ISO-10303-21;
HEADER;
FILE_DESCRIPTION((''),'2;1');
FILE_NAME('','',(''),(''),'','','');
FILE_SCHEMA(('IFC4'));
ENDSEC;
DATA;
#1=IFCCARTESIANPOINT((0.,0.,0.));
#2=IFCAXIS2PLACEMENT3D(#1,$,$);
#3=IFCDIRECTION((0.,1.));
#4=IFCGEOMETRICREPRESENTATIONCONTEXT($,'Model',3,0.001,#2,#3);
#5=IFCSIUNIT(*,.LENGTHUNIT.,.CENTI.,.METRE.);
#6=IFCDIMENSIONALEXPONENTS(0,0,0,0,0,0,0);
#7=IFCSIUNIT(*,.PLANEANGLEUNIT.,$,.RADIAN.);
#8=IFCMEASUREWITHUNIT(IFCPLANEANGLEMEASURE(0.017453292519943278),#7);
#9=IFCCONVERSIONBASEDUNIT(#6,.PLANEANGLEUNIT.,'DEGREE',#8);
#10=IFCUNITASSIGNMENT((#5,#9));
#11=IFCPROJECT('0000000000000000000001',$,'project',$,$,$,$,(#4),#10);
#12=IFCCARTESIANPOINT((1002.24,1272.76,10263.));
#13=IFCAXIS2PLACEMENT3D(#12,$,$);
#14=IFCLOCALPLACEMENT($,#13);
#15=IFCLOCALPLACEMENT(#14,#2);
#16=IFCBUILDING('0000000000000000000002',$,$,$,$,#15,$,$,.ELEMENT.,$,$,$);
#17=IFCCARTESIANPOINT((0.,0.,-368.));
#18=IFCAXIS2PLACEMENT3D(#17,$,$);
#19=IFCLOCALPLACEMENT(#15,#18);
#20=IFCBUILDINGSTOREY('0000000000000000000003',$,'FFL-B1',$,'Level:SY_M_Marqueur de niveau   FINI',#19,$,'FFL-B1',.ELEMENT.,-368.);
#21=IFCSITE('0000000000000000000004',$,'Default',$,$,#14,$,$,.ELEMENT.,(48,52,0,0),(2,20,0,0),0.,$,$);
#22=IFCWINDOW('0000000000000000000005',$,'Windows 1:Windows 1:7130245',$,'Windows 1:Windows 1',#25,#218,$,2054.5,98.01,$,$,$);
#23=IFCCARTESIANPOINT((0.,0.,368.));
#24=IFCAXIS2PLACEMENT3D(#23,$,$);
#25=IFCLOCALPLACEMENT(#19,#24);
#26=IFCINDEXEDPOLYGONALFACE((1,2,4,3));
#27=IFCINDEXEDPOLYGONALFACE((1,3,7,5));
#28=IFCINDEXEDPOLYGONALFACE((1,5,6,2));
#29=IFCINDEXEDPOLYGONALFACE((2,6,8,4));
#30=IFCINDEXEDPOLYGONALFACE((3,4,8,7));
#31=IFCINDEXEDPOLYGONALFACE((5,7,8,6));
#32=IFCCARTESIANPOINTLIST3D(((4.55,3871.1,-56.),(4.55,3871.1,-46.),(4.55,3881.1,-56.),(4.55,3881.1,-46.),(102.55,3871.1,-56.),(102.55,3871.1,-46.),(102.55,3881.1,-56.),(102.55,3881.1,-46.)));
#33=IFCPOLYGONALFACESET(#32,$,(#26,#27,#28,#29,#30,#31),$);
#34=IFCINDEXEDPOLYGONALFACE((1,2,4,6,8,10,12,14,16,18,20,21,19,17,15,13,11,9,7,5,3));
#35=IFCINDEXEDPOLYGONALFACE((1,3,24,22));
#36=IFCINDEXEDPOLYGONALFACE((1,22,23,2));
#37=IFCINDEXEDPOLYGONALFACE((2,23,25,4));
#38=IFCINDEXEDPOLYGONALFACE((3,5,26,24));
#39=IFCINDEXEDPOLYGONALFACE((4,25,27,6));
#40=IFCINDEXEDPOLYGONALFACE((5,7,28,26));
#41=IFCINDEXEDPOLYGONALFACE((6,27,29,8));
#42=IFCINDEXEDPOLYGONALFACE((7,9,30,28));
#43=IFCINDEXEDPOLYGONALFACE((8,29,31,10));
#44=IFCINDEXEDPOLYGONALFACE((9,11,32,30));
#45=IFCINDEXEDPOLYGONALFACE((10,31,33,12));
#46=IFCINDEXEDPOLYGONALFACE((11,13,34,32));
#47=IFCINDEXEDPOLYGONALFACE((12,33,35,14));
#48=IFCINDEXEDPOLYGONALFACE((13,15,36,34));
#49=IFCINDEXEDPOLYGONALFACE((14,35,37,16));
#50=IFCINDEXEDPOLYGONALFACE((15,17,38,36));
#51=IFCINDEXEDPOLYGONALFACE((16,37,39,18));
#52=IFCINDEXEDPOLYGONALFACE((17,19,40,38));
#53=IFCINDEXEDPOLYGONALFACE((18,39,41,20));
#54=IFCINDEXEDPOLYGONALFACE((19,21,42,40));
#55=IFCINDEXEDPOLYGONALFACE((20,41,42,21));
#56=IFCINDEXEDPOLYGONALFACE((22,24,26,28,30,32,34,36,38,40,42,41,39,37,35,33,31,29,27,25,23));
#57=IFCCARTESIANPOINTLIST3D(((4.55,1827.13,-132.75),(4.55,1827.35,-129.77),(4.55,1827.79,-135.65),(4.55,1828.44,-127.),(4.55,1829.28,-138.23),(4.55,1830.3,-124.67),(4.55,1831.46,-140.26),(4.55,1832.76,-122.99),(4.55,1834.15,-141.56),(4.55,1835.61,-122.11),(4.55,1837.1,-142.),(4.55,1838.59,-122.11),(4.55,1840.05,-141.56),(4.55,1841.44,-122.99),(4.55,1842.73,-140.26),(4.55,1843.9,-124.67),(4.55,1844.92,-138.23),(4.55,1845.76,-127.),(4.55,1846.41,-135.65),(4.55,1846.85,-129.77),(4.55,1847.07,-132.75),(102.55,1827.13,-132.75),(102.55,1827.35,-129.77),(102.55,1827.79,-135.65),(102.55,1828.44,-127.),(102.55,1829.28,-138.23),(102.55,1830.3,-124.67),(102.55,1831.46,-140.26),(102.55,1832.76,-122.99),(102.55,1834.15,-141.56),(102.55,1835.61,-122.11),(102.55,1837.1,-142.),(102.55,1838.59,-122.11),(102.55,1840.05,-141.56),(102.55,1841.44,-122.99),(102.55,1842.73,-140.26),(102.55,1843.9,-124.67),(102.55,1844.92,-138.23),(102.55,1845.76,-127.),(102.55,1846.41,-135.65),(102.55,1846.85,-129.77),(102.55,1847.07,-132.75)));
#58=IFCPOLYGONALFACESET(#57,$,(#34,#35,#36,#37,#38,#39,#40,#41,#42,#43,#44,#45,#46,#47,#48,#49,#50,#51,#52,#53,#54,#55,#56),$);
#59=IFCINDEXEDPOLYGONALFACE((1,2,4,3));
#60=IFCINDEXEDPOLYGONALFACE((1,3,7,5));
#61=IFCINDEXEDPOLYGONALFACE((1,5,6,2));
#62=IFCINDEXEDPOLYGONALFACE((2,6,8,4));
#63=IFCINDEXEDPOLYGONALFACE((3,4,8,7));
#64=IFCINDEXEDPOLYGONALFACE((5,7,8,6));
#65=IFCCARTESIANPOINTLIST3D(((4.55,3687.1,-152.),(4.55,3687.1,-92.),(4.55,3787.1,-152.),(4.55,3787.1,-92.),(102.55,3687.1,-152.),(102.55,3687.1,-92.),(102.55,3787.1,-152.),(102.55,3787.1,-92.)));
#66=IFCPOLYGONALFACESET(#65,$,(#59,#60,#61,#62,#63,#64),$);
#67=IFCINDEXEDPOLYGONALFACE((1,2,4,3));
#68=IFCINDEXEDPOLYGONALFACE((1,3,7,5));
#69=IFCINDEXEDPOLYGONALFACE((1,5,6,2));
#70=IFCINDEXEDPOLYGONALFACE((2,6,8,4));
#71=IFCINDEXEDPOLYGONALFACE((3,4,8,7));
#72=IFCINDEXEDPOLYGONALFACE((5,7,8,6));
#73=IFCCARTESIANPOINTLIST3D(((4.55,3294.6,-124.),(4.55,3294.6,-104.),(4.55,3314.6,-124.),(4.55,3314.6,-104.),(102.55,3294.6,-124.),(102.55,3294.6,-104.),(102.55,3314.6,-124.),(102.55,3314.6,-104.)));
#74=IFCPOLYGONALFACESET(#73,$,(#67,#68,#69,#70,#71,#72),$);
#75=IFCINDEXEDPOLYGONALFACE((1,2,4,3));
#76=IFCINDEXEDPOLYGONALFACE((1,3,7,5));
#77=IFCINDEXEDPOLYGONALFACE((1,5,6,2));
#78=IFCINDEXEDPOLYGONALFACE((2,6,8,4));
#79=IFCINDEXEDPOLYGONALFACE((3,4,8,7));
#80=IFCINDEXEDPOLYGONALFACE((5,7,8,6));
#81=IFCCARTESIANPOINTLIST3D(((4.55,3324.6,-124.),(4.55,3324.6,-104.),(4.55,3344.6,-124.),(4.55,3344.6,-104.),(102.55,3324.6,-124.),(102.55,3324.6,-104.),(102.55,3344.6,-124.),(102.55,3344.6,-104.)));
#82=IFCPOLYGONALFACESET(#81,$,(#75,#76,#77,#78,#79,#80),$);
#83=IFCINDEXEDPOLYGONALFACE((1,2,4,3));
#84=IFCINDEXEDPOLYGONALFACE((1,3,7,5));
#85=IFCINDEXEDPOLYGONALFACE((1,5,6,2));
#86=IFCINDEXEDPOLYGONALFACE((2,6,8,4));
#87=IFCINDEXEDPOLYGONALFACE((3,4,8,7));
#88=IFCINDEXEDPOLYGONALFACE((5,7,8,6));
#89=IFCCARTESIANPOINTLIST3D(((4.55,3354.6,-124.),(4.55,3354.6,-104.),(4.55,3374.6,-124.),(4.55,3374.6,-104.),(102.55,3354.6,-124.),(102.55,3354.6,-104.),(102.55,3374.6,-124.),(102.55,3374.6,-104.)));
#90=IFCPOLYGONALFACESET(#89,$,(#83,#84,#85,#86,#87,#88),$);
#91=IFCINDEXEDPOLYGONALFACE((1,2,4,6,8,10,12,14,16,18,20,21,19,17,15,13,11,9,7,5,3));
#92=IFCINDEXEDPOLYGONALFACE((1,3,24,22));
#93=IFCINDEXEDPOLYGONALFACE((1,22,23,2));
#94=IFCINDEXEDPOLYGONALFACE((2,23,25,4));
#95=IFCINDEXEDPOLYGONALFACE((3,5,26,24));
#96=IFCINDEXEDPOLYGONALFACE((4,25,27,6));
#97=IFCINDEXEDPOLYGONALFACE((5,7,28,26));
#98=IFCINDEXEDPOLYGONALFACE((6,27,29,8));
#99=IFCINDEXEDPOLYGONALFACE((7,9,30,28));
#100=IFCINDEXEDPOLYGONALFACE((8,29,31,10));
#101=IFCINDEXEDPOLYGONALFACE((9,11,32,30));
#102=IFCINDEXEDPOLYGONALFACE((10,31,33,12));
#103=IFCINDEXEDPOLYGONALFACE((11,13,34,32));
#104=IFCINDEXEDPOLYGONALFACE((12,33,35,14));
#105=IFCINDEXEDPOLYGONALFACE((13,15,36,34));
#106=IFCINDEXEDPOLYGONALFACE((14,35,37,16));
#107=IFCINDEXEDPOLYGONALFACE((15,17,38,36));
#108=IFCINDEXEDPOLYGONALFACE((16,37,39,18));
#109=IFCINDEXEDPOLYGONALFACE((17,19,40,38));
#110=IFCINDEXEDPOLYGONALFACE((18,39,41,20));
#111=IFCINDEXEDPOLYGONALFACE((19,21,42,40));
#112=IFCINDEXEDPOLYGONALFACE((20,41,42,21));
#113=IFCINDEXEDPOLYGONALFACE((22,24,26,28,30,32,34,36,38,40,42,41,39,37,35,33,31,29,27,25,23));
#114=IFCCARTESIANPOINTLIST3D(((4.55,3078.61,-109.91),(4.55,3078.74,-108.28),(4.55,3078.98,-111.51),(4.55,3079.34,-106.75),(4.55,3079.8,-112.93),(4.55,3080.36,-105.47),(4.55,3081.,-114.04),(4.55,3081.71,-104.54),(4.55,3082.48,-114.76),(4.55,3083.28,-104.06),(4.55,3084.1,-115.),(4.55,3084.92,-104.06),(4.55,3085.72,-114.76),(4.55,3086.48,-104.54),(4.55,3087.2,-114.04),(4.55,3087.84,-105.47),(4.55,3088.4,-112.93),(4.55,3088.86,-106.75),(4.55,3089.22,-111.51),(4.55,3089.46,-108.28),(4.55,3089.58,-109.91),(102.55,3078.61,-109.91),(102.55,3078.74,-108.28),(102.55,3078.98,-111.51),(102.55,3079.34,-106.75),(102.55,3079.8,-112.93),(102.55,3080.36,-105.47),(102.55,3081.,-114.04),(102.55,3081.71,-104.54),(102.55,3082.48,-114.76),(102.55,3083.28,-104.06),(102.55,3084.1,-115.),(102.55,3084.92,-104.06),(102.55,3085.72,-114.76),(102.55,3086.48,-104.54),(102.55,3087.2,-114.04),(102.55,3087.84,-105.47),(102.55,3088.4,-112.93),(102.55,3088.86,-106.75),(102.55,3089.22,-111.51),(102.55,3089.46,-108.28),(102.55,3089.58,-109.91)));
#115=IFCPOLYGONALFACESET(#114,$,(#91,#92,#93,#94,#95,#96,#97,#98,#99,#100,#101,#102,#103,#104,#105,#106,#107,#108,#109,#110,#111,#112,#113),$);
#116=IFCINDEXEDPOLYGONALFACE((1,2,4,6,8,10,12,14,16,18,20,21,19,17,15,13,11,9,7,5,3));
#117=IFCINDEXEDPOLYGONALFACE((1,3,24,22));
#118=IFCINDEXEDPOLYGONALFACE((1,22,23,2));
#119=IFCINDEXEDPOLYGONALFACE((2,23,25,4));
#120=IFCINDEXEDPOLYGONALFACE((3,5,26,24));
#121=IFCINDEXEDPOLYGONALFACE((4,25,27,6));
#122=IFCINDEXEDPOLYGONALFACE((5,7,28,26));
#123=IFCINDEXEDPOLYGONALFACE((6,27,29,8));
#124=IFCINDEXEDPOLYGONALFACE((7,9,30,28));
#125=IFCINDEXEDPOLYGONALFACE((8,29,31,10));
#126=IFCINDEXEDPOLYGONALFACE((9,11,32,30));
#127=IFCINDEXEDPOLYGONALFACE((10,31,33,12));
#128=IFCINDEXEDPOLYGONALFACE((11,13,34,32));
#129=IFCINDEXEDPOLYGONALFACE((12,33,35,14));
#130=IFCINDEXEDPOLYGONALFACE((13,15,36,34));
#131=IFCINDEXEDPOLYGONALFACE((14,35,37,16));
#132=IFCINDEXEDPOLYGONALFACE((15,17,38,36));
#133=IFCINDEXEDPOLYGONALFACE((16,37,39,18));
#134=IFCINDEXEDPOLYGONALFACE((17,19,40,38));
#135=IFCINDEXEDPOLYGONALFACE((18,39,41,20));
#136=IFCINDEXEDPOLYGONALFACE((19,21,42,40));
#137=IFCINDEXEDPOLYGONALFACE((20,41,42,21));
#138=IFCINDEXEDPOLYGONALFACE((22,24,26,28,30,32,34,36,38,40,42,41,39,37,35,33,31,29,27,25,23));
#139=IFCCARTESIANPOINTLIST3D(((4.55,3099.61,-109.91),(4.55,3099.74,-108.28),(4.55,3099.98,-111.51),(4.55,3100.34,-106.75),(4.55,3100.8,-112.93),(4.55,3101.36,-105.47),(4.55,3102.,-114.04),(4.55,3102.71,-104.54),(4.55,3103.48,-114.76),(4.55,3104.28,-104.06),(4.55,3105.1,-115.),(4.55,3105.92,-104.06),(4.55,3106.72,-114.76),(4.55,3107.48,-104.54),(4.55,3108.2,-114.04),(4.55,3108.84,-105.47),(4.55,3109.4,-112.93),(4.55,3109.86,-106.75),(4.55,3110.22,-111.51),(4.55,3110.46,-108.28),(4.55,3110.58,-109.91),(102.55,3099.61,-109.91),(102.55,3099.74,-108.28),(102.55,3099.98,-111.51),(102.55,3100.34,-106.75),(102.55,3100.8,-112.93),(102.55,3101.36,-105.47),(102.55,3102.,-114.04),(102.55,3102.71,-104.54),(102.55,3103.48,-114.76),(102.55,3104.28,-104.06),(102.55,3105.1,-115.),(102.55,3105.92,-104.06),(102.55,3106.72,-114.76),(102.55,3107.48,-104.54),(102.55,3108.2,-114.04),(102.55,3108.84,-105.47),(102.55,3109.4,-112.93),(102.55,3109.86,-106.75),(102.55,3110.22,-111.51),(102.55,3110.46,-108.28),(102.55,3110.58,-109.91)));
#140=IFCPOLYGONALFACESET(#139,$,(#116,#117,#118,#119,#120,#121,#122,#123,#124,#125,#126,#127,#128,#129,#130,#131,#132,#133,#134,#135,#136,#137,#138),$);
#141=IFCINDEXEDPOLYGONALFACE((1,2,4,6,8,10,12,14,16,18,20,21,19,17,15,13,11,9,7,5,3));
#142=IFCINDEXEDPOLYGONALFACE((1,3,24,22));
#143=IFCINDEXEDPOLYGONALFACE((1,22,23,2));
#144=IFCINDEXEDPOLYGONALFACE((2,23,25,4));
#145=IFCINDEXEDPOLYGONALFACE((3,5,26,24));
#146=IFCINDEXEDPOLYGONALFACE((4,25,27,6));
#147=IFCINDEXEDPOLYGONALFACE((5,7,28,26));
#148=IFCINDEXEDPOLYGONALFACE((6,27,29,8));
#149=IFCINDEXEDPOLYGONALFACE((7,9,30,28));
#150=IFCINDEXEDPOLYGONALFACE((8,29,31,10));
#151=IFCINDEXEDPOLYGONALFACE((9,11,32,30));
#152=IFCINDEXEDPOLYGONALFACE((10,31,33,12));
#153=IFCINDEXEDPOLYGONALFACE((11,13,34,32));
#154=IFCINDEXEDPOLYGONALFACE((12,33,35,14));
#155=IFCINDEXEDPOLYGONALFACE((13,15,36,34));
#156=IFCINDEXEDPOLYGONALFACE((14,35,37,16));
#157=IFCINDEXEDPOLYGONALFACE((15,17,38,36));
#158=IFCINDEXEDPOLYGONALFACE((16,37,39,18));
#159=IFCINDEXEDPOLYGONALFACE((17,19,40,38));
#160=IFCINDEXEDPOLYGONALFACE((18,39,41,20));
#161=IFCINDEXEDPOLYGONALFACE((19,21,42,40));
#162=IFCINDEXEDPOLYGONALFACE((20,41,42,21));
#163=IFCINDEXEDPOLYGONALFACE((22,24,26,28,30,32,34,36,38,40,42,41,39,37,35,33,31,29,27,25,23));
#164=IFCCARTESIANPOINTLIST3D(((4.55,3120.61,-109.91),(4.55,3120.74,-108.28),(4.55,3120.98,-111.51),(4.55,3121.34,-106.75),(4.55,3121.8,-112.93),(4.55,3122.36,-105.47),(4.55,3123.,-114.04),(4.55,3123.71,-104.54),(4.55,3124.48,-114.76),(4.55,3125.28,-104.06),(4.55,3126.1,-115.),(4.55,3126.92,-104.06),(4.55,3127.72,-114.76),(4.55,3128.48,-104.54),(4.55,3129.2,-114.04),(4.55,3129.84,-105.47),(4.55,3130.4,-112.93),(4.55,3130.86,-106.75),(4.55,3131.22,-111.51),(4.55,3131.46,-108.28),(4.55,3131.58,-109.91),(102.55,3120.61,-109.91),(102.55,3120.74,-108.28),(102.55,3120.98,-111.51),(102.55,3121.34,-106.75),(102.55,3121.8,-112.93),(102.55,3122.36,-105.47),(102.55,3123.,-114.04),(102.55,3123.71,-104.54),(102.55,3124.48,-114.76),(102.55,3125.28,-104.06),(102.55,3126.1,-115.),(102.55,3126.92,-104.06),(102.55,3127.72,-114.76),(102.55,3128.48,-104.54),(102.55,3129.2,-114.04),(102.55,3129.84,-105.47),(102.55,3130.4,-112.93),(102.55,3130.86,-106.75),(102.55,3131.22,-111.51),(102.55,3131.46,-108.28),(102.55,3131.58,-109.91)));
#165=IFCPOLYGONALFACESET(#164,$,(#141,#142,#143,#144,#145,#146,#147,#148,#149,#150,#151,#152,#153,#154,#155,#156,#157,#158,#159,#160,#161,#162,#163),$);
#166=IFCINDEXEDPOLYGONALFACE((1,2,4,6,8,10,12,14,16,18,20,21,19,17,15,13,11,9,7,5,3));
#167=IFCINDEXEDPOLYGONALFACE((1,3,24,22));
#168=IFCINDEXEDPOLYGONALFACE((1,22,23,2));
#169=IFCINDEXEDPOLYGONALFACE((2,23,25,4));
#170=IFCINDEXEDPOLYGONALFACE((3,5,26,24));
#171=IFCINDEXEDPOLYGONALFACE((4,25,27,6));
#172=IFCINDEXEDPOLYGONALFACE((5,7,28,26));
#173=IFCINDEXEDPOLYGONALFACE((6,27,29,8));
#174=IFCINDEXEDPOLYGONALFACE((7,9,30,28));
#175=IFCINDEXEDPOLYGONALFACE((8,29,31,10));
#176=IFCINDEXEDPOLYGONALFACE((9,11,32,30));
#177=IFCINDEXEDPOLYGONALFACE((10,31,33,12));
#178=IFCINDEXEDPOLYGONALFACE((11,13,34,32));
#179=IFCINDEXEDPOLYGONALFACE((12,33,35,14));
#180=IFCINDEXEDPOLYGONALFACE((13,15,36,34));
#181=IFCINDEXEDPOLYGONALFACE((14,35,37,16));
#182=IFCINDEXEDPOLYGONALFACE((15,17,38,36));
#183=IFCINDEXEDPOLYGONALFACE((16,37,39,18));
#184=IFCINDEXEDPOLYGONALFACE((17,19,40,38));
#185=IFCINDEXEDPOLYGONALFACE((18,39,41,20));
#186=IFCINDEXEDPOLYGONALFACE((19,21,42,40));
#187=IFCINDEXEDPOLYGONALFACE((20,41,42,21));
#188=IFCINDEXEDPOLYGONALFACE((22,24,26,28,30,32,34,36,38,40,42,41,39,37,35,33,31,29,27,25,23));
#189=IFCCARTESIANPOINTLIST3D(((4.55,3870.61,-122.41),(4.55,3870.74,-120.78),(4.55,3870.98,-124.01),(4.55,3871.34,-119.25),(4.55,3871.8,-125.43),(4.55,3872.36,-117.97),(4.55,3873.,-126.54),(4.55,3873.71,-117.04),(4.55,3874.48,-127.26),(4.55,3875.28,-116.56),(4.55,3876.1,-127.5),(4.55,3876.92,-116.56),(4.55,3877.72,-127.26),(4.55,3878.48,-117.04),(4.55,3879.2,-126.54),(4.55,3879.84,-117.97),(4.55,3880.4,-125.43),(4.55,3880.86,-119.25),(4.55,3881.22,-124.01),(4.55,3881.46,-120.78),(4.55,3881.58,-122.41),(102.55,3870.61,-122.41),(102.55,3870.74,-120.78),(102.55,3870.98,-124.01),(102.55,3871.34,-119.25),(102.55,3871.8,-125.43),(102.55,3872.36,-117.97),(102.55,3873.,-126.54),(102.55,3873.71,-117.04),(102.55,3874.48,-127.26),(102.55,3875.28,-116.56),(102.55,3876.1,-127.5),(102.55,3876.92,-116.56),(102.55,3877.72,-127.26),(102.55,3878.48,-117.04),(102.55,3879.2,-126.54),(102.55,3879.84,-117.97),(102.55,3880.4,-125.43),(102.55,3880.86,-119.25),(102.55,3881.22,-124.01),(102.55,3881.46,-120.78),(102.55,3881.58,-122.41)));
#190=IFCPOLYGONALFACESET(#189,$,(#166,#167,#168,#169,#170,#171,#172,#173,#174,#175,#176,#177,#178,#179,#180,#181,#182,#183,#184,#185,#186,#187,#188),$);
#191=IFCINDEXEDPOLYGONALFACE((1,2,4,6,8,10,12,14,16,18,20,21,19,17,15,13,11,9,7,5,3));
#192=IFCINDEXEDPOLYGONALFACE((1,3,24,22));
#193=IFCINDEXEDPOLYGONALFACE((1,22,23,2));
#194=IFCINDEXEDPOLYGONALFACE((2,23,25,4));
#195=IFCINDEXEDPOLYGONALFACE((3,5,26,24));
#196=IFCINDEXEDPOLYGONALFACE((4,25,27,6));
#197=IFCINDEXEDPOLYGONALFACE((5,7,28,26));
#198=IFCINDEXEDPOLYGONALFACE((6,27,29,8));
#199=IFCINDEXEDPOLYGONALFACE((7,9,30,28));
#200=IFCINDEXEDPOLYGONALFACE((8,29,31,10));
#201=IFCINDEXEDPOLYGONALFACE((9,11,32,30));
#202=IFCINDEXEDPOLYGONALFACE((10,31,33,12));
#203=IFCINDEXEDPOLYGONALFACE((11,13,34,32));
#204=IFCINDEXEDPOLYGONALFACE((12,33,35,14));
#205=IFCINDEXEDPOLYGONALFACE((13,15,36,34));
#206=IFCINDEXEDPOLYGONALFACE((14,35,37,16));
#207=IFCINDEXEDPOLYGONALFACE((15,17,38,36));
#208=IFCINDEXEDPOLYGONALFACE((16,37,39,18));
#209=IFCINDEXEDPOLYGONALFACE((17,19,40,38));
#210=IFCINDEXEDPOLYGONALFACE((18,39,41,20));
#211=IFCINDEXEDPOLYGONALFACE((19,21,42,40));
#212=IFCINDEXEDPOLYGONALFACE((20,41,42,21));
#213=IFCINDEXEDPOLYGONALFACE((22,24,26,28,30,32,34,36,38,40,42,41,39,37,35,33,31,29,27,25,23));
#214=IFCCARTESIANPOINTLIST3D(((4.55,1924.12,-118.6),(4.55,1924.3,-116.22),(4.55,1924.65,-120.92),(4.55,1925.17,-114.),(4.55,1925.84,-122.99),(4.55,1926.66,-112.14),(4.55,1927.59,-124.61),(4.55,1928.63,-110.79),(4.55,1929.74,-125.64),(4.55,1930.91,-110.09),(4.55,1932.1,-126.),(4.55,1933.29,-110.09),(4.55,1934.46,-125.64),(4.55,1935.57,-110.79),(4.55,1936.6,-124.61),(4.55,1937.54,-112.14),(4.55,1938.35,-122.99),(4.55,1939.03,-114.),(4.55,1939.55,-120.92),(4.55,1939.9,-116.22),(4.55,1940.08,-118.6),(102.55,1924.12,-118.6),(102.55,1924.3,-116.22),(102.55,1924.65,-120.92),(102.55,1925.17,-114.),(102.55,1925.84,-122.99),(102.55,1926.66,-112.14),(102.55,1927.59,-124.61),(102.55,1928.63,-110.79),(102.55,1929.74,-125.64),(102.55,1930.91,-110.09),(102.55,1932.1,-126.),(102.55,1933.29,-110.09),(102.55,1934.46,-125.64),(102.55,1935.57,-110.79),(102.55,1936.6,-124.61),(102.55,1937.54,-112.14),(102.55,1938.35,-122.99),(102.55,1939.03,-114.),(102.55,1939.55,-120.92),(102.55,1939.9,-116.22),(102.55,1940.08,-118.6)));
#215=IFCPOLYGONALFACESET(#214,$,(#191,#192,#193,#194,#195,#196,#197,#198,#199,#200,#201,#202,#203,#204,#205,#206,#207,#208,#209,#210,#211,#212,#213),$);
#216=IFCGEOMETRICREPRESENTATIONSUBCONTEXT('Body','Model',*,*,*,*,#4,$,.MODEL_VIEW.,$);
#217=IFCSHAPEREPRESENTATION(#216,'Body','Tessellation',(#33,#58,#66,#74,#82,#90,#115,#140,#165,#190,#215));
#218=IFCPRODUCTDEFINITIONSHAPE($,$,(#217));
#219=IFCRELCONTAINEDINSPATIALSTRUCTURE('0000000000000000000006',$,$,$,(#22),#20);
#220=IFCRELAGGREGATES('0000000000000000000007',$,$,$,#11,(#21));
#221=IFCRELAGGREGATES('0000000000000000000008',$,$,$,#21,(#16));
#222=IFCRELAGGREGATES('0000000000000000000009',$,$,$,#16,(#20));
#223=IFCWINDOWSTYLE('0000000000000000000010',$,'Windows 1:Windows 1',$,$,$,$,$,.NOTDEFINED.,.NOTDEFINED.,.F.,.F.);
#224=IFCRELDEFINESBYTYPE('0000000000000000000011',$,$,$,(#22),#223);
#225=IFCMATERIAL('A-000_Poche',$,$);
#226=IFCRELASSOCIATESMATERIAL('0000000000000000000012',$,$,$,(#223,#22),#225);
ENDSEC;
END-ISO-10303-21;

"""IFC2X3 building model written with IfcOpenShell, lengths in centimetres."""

from ifc_helpers import new_model, entity, si_unit, converted_unit, direction, frame, frame_2d, origin, origin_2d_with_axis, place, context, subcontext, project, spatial, rectangle, circle, extrude, source, transform, mapped, material, type_object, type_shapes, element, save


model = new_model("IFC2X3")

# Units and contexts
model_context = context("Model", 3, precision=0.001, world=origin(), true_north=direction((0.0, 1.0)))
body_context = subcontext(model_context, "Body", "Model", "MODEL_VIEW")
ifc_project = project(units=[si_unit("LENGTHUNIT", "METRE", prefix="CENTI"), converted_unit("PLANEANGLEUNIT", "DEGREE", entity("IfcPlaneAngleMeasure", 0.017453292519943278), si_unit("PLANEANGLEUNIT", "RADIAN"), dimensions=[0, 0, 0, 0, 0, 0, 0])], contexts=[model_context])

# Site, building, storey
site_placement = place(None, frame((1002.24, 1272.76, 10263.0)))
site = spatial("IfcSite", under=ifc_project, at=site_placement, Name="Default", CompositionType="ELEMENT", RefLatitude=(48, 52, 0, 0), RefLongitude=(2, 20, 0, 0), RefElevation=0.0)
building_placement = place(site_placement, origin())
building = spatial("IfcBuilding", under=site, at=building_placement, CompositionType="ELEMENT")
storey_placement = place(building_placement, frame((0.0, 0.0, -368.0)))
storey = spatial("IfcBuildingStorey", under=building, at=storey_placement, Name="FFL-B1", ObjectType="Level:SY_M_Marqueur de niveau   FINI", LongName="FFL-B1", CompositionType="ELEMENT", Elevation=-368.0)

# Window
ifc_material_1 = material(Name="A-000_Poche")
window_style = type_object("IfcWindowStyle", Name="Windows 1:Windows 1", ConstructionType="NOTDEFINED", OperationType="NOTDEFINED", ParameterTakesPrecedence=False, Sizeable=False, material=ifc_material_1)
shared_shape_1 = source(origin(), body_context, "Body", "SweptSolid", [
    extrude(rectangle(XDim=98.01, YDim=10.0, at=frame_2d((0.0, 0.0), x_axis=(1.0, 0.0))), frame((53.55, 3876.1, -56.0), z_axis=(0.0, 0.0, 1.0), x_axis=(-1.0, 0.0, 0.0)), (0.0, 0.0, 1.0), 10.0),
    extrude(circle(Radius=10.0, at=origin_2d_with_axis()), frame((4.55, 1837.1, -132.0), z_axis=(1.0, 0.0, 0.0), x_axis=(0.0, 0.0, -1.0)), (0.0, 0.0, 1.0), 98.01),
    extrude(rectangle(XDim=98.01, YDim=100.0, at=frame_2d((0.0, 0.0), x_axis=(1.0, 0.0))), frame((53.55, 3737.1, -152.0), z_axis=(0.0, 0.0, 1.0), x_axis=(-1.0, 0.0, 0.0)), (0.0, 0.0, 1.0), 60.0),
    extrude(rectangle(XDim=98.01, YDim=20.0, at=frame_2d((0.0, 0.0), x_axis=(1.0, 0.0))), frame((53.55, 3304.6, -124.0), z_axis=(0.0, 0.0, 1.0), x_axis=(-1.0, 0.0, 0.0)), (0.0, 0.0, 1.0), 20.0),
    extrude(rectangle(XDim=98.01, YDim=20.0, at=frame_2d((0.0, 0.0), x_axis=(1.0, 0.0))), frame((53.55, 3334.6, -124.0), z_axis=(0.0, 0.0, 1.0), x_axis=(-1.0, 0.0, 0.0)), (0.0, 0.0, 1.0), 20.0),
    extrude(rectangle(XDim=98.01, YDim=20.0, at=origin_2d_with_axis()), frame((53.55, 3364.6, -124.0), z_axis=(0.0, 0.0, 1.0), x_axis=(-1.0, 0.0, 0.0)), (0.0, 0.0, 1.0), 20.0),
    extrude(circle(Radius=5.5, at=origin_2d_with_axis()), frame((4.55, 3084.1, -109.5), z_axis=(1.0, 0.0, 0.0), x_axis=(0.0, 0.0, -1.0)), (0.0, 0.0, 1.0), 98.01),
    extrude(circle(Radius=5.5, at=origin_2d_with_axis()), frame((4.55, 3105.1, -109.5), z_axis=(1.0, 0.0, 0.0), x_axis=(0.0, 0.0, -1.0)), (0.0, 0.0, 1.0), 98.01),
    extrude(circle(Radius=5.5, at=origin_2d_with_axis()), frame((4.55, 3126.1, -109.5), z_axis=(1.0, 0.0, 0.0), x_axis=(0.0, 0.0, -1.0)), (0.0, 0.0, 1.0), 98.01),
    extrude(circle(Radius=5.5, at=origin_2d_with_axis()), frame((4.55, 3876.1, -122.0), z_axis=(1.0, 0.0, 0.0), x_axis=(0.0, 0.0, -1.0)), (0.0, 0.0, 1.0), 98.01),
    extrude(circle(Radius=8.0, at=origin_2d_with_axis()), frame((4.55, 1932.1, -118.0), z_axis=(1.0, 0.0, 0.0), x_axis=(0.0, 0.0, -1.0)), (0.0, 0.0, 1.0), 98.01),
])
type_shapes(window_style, [shared_shape_1])
window_placement = place(storey_placement, frame((0.0, 0.0, 368.0)))
element("IfcWindow", 1, at=window_placement, inside=storey, type_object=window_style, material=ifc_material_1, Name="Windows 1:Windows 1:7130245", ObjectType="Windows 1:Windows 1", OverallHeight=2054.5, OverallWidth=98.01, context=body_context, shape_type="MappedRepresentation", body=[
    mapped(shared_shape_1, transform((0.0, 0.0, 0.0), scale=1.0)),
])

save(model, "model.ifc")
